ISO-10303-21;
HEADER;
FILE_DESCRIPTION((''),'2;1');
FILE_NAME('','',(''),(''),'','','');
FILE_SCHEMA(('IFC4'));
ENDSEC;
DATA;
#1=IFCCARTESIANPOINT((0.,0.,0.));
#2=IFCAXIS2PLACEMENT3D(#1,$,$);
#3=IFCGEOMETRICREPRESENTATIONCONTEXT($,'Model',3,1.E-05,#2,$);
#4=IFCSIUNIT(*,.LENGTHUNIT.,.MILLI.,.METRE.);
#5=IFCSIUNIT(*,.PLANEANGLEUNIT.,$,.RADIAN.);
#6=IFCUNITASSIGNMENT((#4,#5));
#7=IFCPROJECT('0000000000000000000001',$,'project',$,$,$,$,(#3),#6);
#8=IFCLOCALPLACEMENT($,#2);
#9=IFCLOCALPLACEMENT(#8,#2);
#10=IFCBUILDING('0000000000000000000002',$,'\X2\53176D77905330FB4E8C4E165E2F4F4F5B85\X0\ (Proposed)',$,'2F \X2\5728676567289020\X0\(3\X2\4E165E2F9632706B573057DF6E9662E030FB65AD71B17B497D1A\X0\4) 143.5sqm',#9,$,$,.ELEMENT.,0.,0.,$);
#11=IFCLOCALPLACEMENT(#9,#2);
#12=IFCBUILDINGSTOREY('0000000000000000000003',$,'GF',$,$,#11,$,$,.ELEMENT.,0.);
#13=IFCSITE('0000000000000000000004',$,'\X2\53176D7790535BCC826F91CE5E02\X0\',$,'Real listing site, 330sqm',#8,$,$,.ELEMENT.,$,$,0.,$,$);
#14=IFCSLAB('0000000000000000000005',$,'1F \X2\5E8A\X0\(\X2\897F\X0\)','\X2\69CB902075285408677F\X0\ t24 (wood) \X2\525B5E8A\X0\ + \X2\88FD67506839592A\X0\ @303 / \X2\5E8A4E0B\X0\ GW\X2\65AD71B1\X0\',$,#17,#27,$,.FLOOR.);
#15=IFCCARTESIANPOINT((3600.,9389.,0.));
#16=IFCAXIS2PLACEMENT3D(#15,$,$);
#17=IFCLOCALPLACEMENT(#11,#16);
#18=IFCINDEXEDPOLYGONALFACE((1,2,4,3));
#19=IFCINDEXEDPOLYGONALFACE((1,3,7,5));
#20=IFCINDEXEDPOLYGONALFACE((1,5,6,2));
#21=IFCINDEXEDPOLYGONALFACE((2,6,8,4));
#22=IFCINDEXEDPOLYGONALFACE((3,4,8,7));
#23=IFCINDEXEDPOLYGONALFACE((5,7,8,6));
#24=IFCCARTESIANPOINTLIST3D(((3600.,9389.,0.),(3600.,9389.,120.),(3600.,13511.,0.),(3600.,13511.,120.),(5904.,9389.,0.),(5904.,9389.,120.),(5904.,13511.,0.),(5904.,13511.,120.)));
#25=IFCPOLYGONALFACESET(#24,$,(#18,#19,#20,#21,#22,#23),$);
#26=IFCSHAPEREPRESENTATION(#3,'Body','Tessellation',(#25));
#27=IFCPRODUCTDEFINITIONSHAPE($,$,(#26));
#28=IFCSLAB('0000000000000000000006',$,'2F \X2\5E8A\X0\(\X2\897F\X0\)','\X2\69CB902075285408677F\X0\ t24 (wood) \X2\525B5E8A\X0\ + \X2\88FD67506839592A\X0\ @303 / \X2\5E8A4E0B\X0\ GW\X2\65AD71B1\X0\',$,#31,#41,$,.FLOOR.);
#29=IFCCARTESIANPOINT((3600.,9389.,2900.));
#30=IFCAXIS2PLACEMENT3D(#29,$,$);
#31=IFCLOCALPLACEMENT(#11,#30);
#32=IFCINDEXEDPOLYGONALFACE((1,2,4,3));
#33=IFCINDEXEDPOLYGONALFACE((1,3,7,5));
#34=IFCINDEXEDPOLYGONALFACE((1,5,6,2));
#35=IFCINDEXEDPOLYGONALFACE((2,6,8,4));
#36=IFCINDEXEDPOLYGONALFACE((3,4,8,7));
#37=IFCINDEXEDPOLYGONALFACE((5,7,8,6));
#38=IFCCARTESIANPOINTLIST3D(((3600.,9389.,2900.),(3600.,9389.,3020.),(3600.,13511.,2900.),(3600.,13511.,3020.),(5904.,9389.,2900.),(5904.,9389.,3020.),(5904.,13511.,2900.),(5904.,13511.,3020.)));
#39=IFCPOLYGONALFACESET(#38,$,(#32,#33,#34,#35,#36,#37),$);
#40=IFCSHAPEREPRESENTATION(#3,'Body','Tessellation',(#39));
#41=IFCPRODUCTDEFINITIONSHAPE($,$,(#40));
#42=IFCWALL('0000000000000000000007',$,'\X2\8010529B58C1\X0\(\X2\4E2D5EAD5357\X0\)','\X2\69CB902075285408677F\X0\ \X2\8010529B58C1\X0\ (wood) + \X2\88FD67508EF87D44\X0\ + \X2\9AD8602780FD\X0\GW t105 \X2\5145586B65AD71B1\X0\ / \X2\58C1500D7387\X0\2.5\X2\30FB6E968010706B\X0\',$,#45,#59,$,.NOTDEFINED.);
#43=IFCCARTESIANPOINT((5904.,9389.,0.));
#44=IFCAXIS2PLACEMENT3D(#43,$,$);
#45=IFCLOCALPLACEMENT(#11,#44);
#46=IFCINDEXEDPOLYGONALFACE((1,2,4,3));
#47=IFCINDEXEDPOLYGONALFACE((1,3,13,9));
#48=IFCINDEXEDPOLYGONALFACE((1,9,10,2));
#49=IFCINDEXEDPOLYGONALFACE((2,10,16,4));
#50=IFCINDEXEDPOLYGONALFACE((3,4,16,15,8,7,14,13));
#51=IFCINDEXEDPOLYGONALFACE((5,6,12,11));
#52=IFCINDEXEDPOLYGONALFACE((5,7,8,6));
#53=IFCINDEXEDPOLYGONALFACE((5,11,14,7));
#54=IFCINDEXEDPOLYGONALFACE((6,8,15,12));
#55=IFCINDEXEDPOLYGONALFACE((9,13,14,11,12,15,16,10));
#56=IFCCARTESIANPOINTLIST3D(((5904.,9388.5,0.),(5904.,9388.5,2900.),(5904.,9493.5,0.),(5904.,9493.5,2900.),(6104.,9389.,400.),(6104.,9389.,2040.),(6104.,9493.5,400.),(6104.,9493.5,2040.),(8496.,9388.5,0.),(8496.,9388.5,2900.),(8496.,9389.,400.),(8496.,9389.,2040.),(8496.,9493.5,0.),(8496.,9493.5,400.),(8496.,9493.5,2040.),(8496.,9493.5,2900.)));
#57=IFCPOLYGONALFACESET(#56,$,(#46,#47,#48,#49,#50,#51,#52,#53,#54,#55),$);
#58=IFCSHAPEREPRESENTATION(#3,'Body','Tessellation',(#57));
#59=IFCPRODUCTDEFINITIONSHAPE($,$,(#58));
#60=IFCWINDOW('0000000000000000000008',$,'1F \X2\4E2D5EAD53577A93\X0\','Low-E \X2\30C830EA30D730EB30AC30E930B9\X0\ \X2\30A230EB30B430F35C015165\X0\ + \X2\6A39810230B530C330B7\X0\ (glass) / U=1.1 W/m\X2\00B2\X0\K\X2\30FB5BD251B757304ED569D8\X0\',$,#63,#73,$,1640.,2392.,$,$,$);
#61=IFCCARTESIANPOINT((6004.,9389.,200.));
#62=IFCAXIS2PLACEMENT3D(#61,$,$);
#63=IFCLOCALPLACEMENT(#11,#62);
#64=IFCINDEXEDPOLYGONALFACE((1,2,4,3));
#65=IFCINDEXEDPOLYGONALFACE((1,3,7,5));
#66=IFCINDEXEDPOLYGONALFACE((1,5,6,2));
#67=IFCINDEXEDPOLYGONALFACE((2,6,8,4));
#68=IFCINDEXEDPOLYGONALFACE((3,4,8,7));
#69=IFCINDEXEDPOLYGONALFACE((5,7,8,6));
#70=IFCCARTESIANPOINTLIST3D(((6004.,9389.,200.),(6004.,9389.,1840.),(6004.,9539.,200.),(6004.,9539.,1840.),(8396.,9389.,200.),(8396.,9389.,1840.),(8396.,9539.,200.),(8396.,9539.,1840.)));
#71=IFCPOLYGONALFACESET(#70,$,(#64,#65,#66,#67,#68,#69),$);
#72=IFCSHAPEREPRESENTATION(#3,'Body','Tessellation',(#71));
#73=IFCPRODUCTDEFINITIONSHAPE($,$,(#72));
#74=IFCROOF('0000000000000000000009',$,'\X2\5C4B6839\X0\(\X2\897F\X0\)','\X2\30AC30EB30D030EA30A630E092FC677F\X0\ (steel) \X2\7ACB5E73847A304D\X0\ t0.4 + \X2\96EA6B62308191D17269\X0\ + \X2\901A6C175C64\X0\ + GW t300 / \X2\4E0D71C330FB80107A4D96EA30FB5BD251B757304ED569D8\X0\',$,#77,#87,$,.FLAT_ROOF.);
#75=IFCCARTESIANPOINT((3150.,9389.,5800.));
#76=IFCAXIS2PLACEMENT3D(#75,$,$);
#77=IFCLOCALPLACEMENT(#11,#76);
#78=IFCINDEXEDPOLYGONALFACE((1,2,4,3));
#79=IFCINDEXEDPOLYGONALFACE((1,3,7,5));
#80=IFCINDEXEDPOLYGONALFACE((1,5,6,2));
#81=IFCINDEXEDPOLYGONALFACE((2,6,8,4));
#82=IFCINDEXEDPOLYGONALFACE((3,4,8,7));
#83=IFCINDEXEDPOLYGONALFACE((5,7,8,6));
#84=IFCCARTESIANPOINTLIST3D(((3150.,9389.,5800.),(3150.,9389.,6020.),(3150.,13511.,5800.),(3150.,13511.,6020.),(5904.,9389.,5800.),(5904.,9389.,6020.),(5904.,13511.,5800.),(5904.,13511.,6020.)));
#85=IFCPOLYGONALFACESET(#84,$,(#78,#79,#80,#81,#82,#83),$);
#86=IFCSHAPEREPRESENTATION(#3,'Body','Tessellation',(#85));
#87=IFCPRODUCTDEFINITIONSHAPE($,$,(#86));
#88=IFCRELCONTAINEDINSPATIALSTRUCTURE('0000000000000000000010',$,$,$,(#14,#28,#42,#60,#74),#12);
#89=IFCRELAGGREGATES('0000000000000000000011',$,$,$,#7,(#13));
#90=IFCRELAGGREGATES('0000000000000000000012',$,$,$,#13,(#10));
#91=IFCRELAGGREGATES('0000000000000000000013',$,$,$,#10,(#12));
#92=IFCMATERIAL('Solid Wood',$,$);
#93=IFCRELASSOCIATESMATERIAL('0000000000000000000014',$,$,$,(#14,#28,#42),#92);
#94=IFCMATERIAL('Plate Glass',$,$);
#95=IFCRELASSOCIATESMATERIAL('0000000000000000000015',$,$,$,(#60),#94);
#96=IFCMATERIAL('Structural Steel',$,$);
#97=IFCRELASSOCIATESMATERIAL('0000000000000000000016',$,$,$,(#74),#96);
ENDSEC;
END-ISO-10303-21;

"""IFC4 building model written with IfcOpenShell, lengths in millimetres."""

from ifc_helpers import new_model, si_unit, frame, frame_2d, origin, place, context, project, spatial, rectangle, extrude, material, element, fill, save


model = new_model("IFC4")

# Units and contexts
model_context = context("Model", 3, precision=1e-05, world=origin())
ifc_project = project(units=[si_unit("LENGTHUNIT", "METRE", prefix="MILLI"), si_unit("PLANEANGLEUNIT", "RADIAN")], contexts=[model_context])

# Site, building, storey
site_placement = place(None, origin())
site = spatial("IfcSite", under=ifc_project, at=site_placement, Name="北海道富良野市", ObjectType="Real listing site, 330sqm", CompositionType="ELEMENT", RefElevation=0.0)
building_placement = place(site_placement, origin())
building = spatial("IfcBuilding", under=site, at=building_placement, Name="北海道・二世帯住宅 (Proposed)", ObjectType="2F 在来木造(3世帯防火地域準拠・断熱等級4) 143.5sqm", CompositionType="ELEMENT", ElevationOfRefHeight=0.0, ElevationOfTerrain=0.0)
storey_placement = place(building_placement, origin())
storey = spatial("IfcBuildingStorey", under=building, at=storey_placement, Name="GF", CompositionType="ELEMENT", Elevation=0.0)

# Shared definitions
ifc_material_1 = material(Name="Solid Wood")

# Slabs
slab_1_placement = place(storey_placement, frame((3600.0, 9389.0, 0.0)))
element("IfcSlab", 1, at=slab_1_placement, inside=storey, material=ifc_material_1, Name="1F 床(西)", Description="構造用合板 t24 (wood) 剛床 + 製材根太 @303 / 床下 GW断熱", PredefinedType="FLOOR", context=model_context, shape_type="SweptSolid", body=[
    extrude(rectangle(XDim=2304.0, YDim=4122.0, at=frame_2d((1152.0, 2061.0))), frame((3600.0, 9389.0, 0.0)), (0.0, 0.0, 1.0), 120.0),
])
slab_2_placement = place(storey_placement, frame((3600.0, 9389.0, 2900.0)))
element("IfcSlab", 2, at=slab_2_placement, inside=storey, material=ifc_material_1, Name="2F 床(西)", Description="構造用合板 t24 (wood) 剛床 + 製材根太 @303 / 床下 GW断熱", PredefinedType="FLOOR", context=model_context, shape_type="SweptSolid", body=[
    extrude(rectangle(XDim=2304.0, YDim=4122.0, at=frame_2d((1152.0, 2061.0))), frame((3600.0, 9389.0, 2900.0)), (0.0, 0.0, 1.0), 120.0),
])

# Wall, opening, window
wall_1_placement = place(storey_placement, frame((5904.0, 9389.0, 0.0)))
wall_1 = element("IfcWall", 3, at=wall_1_placement, inside=storey, material=ifc_material_1, Name="耐力壁(中庭南)", Description="構造用合板 耐力壁 (wood) + 製材軸組 + 高性能GW t105 充填断熱 / 壁倍率2.5・準耐火", PredefinedType="NOTDEFINED", context=model_context, shape_type="SweptSolid", body=[
    extrude(rectangle(XDim=2592.0, YDim=105.0, at=frame_2d((1296.0, 52.0))), frame((5904.0, 9389.0, 0.0)), (0.0, 0.0, 1.0), 2900.0),
])
opening_placement = place(storey_placement, frame((6004.0, 9389.0, 200.0)))
opening = element("IfcOpeningElement", 4, at=opening_placement, cuts=wall_1, PredefinedType="NOTDEFINED", context=model_context, shape_type="SweptSolid", body=[
    extrude(rectangle(XDim=2392.0, YDim=150.0, at=frame_2d((1196.0, 75.0))), frame((6004.0, 9389.0, 200.0)), (0.0, 0.0, 1.0), 1640.0),
])
ifc_material_2 = material(Name="Plate Glass")
window_placement = place(storey_placement, frame((6004.0, 9389.0, 200.0)))
window = element("IfcWindow", 5, at=window_placement, inside=storey, material=ifc_material_2, Name="1F 中庭南窓", Description="Low-E トリプルガラス アルゴン封入 + 樹脂サッシ (glass) / U=1.1 W/m²K・寒冷地仕様", OverallHeight=1640.0, OverallWidth=2392.0, context=model_context, shape_type="SweptSolid", body=[
    extrude(rectangle(XDim=2392.0, YDim=150.0, at=frame_2d((1196.0, 75.0))), frame((6004.0, 9389.0, 200.0)), (0.0, 0.0, 1.0), 1640.0),
])
fill(opening, window)

# Roof
ifc_material_3 = material(Name="Structural Steel")
for number, where, name in (
    (6, (3150.0, 9389.0, 5800.0), "屋根(西)"),
):
    element("IfcRoof", number, at=place(storey_placement, frame(where)), inside=storey, material=ifc_material_3, Name=name, Description="ガルバリウム鋼板 (steel) 立平葺き t0.4 + 雪止め金物 + 通気層 + GW t300 / 不燃・耐積雪・寒冷地仕様", PredefinedType="FLAT_ROOF", context=model_context, shape_type="SweptSolid", body=[
        extrude(rectangle(XDim=2754.0, YDim=4122.0, at=frame_2d((1377.0, 2061.0))), frame((3150.0, 9389.0, 5800.0)), (0.0, 0.0, 1.0), 220.0),
    ])

save(model, "model.ifc")
